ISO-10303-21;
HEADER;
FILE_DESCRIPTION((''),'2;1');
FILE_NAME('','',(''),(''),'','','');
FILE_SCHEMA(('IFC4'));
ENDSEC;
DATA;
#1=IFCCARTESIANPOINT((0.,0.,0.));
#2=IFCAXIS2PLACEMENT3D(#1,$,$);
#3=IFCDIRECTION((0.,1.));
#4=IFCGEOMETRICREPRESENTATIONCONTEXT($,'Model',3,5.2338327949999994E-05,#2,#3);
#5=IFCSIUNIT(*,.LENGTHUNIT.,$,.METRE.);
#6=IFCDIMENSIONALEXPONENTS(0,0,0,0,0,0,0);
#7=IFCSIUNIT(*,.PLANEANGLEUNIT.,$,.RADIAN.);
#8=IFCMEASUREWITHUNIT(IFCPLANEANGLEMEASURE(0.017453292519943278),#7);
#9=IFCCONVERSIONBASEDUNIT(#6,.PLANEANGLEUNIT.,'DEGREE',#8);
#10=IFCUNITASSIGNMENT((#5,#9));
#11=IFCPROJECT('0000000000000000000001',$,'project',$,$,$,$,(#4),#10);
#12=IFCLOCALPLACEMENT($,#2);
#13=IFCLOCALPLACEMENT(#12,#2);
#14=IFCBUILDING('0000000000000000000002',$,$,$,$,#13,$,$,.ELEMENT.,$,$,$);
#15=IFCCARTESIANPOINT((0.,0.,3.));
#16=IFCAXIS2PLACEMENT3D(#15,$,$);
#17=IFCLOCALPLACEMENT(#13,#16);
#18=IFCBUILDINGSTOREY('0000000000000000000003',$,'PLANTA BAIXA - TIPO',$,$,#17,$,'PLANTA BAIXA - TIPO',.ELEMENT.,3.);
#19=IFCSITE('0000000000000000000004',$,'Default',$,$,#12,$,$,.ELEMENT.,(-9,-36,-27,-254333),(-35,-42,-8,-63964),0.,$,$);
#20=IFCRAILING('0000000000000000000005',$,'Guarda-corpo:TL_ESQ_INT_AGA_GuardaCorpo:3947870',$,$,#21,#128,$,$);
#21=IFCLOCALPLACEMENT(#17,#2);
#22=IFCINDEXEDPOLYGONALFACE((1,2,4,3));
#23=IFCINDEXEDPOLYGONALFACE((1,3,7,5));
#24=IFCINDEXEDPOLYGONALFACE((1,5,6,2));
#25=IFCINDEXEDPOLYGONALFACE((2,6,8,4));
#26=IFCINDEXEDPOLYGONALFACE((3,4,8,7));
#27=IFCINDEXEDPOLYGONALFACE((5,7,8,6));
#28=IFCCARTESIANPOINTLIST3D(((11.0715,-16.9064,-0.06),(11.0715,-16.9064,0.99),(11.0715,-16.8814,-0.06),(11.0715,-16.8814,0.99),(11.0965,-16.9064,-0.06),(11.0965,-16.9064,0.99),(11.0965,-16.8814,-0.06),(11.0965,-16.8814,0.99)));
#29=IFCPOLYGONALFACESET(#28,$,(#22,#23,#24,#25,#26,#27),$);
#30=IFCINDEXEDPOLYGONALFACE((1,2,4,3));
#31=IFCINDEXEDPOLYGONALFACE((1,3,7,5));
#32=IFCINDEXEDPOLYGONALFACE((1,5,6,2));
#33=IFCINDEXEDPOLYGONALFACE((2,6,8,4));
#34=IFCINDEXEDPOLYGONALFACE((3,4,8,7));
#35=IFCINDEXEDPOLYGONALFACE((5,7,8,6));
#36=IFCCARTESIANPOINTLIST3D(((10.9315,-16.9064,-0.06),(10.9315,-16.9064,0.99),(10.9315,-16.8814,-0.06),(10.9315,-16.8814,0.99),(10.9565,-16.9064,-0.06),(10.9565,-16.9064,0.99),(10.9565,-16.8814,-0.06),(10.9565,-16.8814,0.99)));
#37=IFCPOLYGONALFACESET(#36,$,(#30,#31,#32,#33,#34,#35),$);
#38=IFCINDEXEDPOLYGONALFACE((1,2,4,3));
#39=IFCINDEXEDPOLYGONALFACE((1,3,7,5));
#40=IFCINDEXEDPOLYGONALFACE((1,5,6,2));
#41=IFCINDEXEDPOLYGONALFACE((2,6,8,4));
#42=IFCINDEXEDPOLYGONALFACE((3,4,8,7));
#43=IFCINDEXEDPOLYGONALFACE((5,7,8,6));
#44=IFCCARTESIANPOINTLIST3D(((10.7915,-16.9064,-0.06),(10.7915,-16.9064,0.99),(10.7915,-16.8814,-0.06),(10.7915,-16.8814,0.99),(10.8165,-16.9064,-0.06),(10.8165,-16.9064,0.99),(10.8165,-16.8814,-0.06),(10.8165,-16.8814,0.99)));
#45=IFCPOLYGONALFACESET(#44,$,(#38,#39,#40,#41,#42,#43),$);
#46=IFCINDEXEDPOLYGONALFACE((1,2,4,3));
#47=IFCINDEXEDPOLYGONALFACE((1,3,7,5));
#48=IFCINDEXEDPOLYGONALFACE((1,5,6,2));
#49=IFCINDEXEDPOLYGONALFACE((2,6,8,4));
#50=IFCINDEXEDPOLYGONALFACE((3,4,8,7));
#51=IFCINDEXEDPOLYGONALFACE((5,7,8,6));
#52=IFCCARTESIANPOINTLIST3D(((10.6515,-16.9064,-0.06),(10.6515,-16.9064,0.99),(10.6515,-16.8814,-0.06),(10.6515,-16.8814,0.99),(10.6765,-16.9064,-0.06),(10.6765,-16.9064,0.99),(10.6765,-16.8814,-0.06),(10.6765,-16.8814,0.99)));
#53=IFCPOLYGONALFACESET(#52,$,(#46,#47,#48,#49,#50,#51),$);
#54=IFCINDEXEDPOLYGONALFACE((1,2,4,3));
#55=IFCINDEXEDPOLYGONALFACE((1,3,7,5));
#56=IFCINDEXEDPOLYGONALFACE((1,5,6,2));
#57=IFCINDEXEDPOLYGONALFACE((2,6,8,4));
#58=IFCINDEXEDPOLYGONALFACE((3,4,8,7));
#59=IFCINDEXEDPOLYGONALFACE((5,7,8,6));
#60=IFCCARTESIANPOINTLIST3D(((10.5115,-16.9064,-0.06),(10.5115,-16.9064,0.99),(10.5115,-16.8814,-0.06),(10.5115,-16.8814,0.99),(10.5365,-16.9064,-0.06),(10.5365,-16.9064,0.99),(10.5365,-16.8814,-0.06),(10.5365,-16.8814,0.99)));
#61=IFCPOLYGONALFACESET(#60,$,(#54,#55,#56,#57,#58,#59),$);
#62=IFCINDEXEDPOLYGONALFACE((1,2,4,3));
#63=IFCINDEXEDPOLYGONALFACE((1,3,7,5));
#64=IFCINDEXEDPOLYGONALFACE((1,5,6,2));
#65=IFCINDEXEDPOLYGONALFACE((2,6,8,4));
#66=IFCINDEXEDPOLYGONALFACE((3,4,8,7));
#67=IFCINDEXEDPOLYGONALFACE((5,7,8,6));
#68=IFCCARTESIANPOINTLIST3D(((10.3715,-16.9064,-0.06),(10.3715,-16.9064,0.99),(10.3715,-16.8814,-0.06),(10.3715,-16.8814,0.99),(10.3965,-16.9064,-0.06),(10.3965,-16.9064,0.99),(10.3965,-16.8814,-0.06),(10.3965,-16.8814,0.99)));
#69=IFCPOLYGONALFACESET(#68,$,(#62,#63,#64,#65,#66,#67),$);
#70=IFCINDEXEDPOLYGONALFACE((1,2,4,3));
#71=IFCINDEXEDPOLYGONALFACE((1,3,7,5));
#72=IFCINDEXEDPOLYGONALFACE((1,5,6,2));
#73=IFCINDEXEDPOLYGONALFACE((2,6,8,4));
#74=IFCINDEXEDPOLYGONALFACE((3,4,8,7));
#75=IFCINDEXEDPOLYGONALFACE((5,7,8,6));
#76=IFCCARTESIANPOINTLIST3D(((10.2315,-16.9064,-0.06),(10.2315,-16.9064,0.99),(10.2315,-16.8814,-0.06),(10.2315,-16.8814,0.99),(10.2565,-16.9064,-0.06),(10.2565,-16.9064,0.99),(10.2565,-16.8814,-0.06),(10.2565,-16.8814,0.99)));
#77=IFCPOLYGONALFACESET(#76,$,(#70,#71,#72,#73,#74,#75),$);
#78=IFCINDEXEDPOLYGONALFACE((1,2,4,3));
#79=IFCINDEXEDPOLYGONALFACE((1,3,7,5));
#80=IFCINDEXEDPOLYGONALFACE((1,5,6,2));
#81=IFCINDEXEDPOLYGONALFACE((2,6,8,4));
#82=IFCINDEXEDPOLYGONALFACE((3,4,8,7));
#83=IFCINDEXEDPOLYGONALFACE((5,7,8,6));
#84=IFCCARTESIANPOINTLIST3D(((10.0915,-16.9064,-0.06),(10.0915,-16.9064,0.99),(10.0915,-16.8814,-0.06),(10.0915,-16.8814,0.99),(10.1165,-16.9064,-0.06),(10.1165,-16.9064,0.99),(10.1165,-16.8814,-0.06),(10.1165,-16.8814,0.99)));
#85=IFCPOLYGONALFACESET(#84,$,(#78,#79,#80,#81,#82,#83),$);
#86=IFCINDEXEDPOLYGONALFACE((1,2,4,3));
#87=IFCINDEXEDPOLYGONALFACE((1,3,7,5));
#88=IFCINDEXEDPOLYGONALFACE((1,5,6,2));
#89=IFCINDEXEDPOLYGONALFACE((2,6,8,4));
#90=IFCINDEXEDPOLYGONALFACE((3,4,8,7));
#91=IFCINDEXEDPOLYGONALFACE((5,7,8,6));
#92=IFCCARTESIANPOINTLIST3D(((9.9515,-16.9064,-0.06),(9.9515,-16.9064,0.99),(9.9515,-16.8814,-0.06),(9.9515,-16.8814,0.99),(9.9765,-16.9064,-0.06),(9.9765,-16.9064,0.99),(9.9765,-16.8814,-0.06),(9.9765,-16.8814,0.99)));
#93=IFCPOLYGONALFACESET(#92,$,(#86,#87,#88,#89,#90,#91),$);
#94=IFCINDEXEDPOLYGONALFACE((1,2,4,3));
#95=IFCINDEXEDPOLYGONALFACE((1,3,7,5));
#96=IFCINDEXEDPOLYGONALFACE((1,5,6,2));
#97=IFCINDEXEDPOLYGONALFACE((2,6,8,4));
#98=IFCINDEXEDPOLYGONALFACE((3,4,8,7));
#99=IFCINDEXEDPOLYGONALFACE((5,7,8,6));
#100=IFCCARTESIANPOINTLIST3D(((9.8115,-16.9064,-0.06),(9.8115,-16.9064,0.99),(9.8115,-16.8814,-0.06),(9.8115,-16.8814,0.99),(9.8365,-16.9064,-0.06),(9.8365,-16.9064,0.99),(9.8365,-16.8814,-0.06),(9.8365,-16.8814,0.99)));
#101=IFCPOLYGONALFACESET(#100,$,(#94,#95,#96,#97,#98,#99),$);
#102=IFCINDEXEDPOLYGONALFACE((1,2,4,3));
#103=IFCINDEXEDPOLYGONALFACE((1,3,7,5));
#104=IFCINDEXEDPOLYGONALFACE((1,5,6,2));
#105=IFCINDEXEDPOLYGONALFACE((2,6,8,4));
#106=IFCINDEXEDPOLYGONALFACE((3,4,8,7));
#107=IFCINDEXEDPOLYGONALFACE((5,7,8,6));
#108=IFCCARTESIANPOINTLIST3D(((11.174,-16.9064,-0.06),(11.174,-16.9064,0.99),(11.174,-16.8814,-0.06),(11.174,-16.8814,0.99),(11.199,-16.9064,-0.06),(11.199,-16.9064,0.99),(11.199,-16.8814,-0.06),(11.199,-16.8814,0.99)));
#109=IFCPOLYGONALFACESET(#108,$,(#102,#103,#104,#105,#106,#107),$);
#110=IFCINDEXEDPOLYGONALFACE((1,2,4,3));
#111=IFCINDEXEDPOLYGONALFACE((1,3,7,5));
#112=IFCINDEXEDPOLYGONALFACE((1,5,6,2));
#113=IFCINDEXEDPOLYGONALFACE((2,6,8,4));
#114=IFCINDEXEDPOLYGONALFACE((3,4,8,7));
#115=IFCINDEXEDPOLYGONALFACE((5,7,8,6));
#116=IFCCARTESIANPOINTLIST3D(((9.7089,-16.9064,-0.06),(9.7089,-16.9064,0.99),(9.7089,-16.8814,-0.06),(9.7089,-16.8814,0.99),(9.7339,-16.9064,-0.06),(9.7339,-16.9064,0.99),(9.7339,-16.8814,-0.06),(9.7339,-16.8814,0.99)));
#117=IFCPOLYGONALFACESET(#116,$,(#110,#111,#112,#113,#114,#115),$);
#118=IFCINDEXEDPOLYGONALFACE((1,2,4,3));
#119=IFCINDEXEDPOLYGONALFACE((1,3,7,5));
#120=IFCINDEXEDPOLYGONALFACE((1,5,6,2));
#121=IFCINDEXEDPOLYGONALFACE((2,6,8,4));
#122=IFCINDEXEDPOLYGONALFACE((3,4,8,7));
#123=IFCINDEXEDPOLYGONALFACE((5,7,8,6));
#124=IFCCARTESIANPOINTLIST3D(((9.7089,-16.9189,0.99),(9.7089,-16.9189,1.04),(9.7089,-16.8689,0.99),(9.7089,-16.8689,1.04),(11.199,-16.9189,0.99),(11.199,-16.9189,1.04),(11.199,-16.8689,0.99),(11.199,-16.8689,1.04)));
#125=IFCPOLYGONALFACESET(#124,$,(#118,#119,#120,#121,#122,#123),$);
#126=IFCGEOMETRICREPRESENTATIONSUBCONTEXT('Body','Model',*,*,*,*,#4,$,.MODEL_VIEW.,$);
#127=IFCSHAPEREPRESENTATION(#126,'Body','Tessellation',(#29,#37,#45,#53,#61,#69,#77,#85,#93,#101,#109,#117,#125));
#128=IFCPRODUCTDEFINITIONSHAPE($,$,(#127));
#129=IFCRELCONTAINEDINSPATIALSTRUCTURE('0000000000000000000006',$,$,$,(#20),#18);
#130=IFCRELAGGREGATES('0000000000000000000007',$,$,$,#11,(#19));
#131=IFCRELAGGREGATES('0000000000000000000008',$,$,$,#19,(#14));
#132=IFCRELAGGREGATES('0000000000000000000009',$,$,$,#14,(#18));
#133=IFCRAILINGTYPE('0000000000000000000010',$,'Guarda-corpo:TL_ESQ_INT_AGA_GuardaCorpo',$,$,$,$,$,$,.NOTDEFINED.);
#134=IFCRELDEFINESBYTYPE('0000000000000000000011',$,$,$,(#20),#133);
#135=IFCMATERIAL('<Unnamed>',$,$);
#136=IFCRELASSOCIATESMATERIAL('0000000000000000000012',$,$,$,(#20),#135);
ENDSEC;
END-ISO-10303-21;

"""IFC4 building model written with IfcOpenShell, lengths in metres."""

from ifc_helpers import new_model, entity, si_unit, converted_unit, direction, frame, frame_2d, origin, origin_2d_with_axis, place, context, subcontext, project, spatial, rectangle, extrude, material, type_object, element, save


model = new_model("IFC4")

# Units and contexts
model_context = context("Model", 3, precision=5.2338327949999994e-05, world=origin(), true_north=direction((0.0, 1.0)))
body_context = subcontext(model_context, "Body", "Model", "MODEL_VIEW")
ifc_project = project(units=[si_unit("LENGTHUNIT", "METRE"), converted_unit("PLANEANGLEUNIT", "DEGREE", entity("IfcPlaneAngleMeasure", 0.017453292519943278), si_unit("PLANEANGLEUNIT", "RADIAN"), dimensions=[0, 0, 0, 0, 0, 0, 0])], contexts=[model_context])

# Site, building, storey
site_placement = place(None, frame((0.0, 0.0, 0.0)))
site = spatial("IfcSite", under=ifc_project, at=site_placement, Name="Default", CompositionType="ELEMENT", RefLatitude=(-9, -36, -27, -254333), RefLongitude=(-35, -42, -8, -63964), RefElevation=0.0)
building_placement = place(site_placement, origin())
building = spatial("IfcBuilding", under=site, at=building_placement, CompositionType="ELEMENT")
storey_placement = place(building_placement, frame((0.0, 0.0, 3.0)))
storey = spatial("IfcBuildingStorey", under=building, at=storey_placement, Name="PLANTA BAIXA - TIPO", LongName="PLANTA BAIXA - TIPO", CompositionType="ELEMENT", Elevation=3.0)

# Railing
ifc_material_1 = material(Name="<Unnamed>")
railing_type = type_object("IfcRailingType", Name="Guarda-corpo:TL_ESQ_INT_AGA_GuardaCorpo", PredefinedType="NOTDEFINED")
railing_placement = place(storey_placement, frame((9.7089, -16.9189, -0.06)))
element("IfcRailing", 1, at=railing_placement, inside=storey, type_object=railing_type, material=ifc_material_1, Name="Guarda-corpo:TL_ESQ_INT_AGA_GuardaCorpo:3947870", context=body_context, shape_type="SweptSolid", body=[
    extrude(rectangle(XDim=0.025, YDim=0.025, at=origin_2d_with_axis()), frame((1.375, 0.025, 0.0)), (0.0, 0.0, 1.0), 1.05),
    extrude(rectangle(XDim=0.025, YDim=0.025, at=origin_2d_with_axis()), frame((1.235, 0.025, 0.0)), (0.0, 0.0, 1.0), 1.05),
    extrude(rectangle(XDim=0.025, YDim=0.025, at=origin_2d_with_axis()), frame((1.095, 0.025, 0.0)), (0.0, 0.0, 1.0), 1.05),
    extrude(rectangle(XDim=0.025, YDim=0.025, at=origin_2d_with_axis()), frame((0.955, 0.025, 0.0)), (0.0, 0.0, 1.0), 1.05),
    extrude(rectangle(XDim=0.025, YDim=0.025, at=origin_2d_with_axis()), frame((0.815, 0.025, 0.0)), (0.0, 0.0, 1.0), 1.05),
    extrude(rectangle(XDim=0.025, YDim=0.025, at=origin_2d_with_axis()), frame((0.675, 0.025, 0.0)), (0.0, 0.0, 1.0), 1.05),
    extrude(rectangle(XDim=0.025, YDim=0.025, at=origin_2d_with_axis()), frame((0.535, 0.025, 0.0)), (0.0, 0.0, 1.0), 1.05),
    extrude(rectangle(XDim=0.025, YDim=0.025, at=origin_2d_with_axis()), frame((0.395, 0.025, 0.0)), (0.0, 0.0, 1.0), 1.05),
    extrude(rectangle(XDim=0.025, YDim=0.025, at=origin_2d_with_axis()), frame((0.255, 0.025, 0.0)), (0.0, 0.0, 1.0), 1.05),
    extrude(rectangle(XDim=0.025, YDim=0.025, at=origin_2d_with_axis()), frame((0.115, 0.025, 0.0)), (0.0, 0.0, 1.0), 1.05),
    extrude(rectangle(XDim=0.025, YDim=0.025, at=origin_2d_with_axis()), frame((1.4775, 0.025, 0.0)), (0.0, 0.0, 1.0), 1.05),
    extrude(rectangle(XDim=0.025, YDim=0.025, at=origin_2d_with_axis()), frame((0.0125, 0.025, 0.0)), (0.0, 0.0, 1.0), 1.05),
    extrude(rectangle(XDim=1.49, YDim=0.05, at=frame_2d((0.0, 0.0), x_axis=(1.0, 0.0))), frame((0.745, 0.025, 1.05)), (0.0, 0.0, 1.0), 0.05),
])

save(model, "model.ifc")
